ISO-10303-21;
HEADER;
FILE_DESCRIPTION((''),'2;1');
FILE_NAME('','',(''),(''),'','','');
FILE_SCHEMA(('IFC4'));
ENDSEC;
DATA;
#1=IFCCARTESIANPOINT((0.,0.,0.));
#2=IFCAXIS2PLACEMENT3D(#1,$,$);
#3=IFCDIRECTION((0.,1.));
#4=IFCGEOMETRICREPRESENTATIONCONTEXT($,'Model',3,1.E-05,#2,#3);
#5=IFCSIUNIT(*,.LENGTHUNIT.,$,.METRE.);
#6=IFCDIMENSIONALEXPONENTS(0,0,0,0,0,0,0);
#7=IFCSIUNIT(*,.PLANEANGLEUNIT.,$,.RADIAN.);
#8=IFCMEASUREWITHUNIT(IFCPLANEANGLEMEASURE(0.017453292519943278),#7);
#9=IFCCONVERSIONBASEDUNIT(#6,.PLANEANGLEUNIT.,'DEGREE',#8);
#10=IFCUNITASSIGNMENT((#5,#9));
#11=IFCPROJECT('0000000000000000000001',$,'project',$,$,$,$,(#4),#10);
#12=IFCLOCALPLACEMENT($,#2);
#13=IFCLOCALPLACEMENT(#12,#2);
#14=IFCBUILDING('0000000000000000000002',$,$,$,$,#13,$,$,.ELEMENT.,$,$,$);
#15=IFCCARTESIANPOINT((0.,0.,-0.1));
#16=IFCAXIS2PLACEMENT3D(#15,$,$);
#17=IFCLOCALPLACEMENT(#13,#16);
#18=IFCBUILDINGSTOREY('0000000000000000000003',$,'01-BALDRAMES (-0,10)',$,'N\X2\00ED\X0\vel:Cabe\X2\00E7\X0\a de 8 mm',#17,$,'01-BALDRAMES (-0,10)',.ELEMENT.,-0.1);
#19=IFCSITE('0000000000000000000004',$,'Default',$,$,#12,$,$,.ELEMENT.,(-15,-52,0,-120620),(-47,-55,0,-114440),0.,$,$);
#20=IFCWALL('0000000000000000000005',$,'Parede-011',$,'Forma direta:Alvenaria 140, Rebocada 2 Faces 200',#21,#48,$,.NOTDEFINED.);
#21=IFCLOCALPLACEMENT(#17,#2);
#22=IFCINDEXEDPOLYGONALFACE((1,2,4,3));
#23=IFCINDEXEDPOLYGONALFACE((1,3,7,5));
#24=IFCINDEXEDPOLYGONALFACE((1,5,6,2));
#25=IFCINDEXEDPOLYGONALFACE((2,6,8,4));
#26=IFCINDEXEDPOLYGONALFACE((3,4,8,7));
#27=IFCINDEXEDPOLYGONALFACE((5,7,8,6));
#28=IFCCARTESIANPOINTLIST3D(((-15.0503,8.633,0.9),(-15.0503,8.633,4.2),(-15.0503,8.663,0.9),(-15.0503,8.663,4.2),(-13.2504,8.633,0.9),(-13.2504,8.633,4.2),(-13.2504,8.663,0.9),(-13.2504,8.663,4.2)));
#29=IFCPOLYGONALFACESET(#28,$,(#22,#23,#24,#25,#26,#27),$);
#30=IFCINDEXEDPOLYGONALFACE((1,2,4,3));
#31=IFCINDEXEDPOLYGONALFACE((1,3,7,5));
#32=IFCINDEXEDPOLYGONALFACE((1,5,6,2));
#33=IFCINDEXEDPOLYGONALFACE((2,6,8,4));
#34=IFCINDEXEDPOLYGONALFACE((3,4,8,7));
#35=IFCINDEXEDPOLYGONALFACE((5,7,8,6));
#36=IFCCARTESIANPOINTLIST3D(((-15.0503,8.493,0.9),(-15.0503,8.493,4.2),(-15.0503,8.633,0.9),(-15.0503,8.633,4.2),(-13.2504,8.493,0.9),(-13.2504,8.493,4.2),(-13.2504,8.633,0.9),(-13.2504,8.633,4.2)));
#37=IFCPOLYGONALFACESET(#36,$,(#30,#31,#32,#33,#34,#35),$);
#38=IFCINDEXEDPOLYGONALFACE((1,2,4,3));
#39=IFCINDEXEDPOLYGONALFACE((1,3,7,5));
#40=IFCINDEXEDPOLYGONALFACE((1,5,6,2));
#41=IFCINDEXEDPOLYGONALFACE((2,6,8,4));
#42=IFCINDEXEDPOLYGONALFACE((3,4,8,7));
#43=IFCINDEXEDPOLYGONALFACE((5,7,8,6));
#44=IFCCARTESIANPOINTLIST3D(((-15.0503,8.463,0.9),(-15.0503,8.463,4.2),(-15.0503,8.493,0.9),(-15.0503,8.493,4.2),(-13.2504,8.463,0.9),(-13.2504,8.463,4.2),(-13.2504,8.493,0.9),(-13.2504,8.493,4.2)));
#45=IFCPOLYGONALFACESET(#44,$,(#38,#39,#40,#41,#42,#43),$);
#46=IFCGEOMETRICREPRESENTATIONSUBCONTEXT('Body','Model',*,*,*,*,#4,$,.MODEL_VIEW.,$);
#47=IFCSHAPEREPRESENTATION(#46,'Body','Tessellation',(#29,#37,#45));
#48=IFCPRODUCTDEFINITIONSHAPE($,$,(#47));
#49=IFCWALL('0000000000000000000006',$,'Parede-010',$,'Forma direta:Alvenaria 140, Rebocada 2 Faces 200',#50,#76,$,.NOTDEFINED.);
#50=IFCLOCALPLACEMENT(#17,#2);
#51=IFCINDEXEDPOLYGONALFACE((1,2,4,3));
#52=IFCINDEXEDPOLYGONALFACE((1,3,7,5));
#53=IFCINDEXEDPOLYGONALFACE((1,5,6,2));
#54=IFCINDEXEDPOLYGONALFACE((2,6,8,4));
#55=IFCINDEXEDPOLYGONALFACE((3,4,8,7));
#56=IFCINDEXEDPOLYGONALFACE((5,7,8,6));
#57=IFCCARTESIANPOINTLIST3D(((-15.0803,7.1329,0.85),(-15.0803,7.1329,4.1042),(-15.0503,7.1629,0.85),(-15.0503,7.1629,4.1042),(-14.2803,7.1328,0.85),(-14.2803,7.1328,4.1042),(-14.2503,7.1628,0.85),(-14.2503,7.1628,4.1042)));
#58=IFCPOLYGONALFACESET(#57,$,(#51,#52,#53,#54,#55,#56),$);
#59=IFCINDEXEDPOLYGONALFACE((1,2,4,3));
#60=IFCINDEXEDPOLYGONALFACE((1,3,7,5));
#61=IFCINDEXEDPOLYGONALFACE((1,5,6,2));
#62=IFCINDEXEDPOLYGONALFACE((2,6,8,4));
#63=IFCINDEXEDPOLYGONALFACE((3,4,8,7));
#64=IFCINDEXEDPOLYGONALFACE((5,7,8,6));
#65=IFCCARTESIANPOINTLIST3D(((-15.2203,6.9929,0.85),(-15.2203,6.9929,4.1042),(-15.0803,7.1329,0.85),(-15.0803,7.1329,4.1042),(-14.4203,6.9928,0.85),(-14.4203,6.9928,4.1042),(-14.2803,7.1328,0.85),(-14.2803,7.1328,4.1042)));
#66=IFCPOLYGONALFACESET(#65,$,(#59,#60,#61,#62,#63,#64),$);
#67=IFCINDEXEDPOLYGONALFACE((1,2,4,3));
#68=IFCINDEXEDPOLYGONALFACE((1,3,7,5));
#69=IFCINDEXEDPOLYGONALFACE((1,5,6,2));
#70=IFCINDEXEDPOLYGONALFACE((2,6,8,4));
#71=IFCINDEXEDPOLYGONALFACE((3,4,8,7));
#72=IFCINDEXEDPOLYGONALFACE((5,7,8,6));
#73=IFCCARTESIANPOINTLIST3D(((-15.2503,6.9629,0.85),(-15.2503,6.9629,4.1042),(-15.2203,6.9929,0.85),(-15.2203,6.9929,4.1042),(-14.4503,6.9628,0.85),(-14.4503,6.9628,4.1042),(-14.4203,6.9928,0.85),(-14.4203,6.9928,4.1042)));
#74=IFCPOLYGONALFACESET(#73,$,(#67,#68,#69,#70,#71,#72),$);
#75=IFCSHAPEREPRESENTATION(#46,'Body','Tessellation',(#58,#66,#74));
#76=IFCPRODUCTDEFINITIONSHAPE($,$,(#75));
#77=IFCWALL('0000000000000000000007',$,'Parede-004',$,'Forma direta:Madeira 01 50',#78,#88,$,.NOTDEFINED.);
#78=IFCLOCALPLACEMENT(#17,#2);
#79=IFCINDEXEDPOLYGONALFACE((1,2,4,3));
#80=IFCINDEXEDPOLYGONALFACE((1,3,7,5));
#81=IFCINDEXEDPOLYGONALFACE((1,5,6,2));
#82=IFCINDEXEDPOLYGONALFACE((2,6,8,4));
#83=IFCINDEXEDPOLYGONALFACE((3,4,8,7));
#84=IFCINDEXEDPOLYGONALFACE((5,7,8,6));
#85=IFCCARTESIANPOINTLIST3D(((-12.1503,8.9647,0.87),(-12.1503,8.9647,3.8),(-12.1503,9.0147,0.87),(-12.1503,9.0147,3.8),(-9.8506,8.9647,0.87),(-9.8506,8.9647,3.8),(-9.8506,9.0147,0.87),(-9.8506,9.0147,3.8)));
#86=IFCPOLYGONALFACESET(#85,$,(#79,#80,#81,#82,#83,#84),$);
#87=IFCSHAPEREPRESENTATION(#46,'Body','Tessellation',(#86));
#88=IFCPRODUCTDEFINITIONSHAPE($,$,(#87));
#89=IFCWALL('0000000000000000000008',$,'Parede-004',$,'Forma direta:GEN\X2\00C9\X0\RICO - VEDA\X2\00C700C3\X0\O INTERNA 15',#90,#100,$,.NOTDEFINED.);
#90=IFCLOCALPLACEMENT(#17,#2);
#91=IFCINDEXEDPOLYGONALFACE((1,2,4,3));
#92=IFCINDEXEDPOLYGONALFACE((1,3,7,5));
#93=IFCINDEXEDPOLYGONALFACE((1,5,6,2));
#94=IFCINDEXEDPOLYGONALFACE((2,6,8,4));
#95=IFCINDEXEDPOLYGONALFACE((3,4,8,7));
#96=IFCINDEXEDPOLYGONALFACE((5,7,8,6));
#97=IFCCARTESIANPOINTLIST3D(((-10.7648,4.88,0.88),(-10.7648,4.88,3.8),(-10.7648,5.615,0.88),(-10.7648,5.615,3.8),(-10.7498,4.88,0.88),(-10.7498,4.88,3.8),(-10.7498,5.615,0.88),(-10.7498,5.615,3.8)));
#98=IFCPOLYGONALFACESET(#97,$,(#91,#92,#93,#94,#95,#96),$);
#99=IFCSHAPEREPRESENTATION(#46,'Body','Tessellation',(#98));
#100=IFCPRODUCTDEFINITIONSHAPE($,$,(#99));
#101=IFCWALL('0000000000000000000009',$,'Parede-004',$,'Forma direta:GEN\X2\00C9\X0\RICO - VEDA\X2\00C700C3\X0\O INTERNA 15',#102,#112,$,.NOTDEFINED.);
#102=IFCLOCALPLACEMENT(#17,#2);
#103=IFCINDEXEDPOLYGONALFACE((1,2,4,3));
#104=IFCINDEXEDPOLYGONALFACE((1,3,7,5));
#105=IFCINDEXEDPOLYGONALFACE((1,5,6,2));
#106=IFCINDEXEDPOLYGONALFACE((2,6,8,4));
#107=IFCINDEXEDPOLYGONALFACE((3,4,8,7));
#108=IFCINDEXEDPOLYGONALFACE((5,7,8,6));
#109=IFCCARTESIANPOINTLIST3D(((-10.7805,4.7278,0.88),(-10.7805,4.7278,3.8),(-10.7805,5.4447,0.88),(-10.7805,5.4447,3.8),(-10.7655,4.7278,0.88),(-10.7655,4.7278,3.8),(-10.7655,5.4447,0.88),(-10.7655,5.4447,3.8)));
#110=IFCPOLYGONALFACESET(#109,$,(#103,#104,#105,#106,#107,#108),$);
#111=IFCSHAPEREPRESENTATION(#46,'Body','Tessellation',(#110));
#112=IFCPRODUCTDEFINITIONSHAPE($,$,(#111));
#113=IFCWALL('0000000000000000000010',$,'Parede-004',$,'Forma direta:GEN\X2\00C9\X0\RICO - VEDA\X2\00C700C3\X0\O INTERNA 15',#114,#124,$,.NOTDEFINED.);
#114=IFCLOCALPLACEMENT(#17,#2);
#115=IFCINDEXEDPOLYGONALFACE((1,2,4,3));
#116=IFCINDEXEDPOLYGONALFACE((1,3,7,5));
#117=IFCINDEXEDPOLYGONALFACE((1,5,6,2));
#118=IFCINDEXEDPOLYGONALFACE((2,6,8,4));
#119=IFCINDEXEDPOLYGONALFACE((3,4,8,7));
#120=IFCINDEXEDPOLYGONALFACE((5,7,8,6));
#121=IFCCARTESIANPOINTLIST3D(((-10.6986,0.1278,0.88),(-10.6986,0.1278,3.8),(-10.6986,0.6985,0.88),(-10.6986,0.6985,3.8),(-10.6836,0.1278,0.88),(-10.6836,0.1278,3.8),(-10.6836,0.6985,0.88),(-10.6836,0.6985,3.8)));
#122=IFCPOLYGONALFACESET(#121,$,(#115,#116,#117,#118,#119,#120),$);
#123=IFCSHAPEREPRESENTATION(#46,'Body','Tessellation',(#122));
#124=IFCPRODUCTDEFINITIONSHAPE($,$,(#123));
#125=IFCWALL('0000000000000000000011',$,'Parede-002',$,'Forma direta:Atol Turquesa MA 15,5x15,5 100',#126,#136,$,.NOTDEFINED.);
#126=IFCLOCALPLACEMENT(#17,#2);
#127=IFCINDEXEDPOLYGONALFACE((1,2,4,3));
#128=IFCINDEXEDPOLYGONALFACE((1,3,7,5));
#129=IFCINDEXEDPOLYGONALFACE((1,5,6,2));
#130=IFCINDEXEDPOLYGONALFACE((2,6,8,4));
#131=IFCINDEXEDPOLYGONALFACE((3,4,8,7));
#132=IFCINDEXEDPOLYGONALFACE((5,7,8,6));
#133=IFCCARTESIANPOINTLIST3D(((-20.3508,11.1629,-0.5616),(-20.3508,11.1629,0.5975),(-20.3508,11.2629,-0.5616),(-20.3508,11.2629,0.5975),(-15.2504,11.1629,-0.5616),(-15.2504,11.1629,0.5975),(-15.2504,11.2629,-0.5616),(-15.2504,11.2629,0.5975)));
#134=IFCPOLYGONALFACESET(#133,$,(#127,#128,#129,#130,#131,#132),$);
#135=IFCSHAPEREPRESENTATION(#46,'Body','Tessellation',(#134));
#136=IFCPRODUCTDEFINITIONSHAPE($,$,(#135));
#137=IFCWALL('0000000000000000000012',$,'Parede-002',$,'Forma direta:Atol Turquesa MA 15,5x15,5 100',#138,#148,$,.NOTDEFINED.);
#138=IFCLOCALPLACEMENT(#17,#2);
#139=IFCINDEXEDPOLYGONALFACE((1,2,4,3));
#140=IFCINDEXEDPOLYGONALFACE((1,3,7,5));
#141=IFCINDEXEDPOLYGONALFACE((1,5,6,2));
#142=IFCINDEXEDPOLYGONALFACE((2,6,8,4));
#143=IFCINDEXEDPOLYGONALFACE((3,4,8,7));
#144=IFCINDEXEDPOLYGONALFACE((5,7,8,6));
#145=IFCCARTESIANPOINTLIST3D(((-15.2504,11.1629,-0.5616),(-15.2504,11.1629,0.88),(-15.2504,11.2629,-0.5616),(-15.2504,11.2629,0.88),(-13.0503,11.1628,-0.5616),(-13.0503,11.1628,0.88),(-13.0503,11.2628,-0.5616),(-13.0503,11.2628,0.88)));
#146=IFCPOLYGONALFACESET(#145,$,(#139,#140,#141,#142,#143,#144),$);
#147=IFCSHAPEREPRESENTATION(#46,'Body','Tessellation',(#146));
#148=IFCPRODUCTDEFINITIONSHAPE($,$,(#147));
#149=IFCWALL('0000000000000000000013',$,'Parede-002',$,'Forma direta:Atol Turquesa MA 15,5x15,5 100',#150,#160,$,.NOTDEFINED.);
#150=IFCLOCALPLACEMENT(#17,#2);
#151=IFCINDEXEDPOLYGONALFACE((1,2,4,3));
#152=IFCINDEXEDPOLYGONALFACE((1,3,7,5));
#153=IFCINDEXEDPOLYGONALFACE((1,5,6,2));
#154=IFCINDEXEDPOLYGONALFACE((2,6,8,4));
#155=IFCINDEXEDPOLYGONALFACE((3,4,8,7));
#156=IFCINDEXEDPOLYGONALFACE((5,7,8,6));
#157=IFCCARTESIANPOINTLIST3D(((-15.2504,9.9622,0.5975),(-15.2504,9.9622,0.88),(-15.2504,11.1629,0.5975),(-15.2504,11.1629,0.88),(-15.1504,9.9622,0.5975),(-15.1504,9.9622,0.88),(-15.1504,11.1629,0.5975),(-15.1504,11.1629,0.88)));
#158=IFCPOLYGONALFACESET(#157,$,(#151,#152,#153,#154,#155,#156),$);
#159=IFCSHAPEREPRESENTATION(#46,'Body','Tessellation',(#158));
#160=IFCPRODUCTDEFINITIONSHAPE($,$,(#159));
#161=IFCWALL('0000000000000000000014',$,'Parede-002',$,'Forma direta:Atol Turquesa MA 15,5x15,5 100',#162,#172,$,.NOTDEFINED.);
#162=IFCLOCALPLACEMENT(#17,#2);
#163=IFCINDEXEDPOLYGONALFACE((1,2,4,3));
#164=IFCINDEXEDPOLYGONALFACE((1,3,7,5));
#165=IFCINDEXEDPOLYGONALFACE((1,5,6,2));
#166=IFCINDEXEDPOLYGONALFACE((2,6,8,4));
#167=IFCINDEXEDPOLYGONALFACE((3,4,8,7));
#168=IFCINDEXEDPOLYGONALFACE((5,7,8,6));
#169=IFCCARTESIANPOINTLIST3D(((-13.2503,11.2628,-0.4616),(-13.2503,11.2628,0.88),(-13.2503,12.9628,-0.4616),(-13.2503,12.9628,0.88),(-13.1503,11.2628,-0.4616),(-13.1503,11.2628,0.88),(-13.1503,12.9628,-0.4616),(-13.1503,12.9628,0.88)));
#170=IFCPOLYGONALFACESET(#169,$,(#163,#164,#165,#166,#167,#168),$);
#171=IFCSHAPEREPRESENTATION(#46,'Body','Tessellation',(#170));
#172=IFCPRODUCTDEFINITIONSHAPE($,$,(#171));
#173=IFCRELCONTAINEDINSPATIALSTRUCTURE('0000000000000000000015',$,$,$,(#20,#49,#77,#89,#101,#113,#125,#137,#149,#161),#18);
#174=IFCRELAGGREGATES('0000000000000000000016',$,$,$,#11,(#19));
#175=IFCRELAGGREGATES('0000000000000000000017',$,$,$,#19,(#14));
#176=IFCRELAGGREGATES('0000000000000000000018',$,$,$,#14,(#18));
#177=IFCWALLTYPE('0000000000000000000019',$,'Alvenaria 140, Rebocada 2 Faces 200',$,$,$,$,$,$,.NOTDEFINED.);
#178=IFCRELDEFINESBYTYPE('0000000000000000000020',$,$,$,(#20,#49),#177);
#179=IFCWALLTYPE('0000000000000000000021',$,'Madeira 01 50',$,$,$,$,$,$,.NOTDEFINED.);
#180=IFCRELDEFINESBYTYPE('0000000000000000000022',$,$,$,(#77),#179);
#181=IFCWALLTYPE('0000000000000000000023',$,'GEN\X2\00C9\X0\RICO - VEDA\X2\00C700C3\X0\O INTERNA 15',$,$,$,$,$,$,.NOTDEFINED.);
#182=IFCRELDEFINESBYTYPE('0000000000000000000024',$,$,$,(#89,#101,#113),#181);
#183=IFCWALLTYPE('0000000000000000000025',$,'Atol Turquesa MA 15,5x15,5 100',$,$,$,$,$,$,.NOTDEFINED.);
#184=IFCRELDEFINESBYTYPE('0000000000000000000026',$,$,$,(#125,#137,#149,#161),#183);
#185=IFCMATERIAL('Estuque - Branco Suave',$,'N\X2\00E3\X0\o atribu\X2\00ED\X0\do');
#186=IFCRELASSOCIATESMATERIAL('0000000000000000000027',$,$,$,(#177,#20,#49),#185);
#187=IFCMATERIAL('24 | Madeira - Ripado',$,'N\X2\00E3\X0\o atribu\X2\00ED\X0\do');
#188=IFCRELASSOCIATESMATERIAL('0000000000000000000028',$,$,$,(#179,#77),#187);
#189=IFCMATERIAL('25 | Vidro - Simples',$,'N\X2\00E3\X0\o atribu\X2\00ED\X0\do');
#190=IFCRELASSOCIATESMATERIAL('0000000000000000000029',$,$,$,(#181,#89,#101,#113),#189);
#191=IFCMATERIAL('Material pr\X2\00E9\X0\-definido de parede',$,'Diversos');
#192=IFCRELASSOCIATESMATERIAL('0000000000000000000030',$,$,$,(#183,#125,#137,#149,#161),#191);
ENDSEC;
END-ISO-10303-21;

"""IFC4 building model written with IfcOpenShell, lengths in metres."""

from ifc_helpers import new_model, entity, si_unit, converted_unit, direction, frame, origin, place, context, subcontext, project, spatial, indexed_curve, outline, extrude, material, type_object, element, save


model = new_model("IFC4")

# Units and contexts
model_context = context("Model", 3, precision=1e-05, world=origin(), true_north=direction((0.0, 1.0)))
body_context = subcontext(model_context, "Body", "Model", "MODEL_VIEW")
ifc_project = project(units=[si_unit("LENGTHUNIT", "METRE"), converted_unit("PLANEANGLEUNIT", "DEGREE", entity("IfcPlaneAngleMeasure", 0.017453292519943278), si_unit("PLANEANGLEUNIT", "RADIAN"), dimensions=[0, 0, 0, 0, 0, 0, 0])], contexts=[model_context])

# Site, building, storey
site_placement = place(None, origin())
site = spatial("IfcSite", under=ifc_project, at=site_placement, Name="Default", CompositionType="ELEMENT", RefLatitude=(-15, -52, 0, -120620), RefLongitude=(-47, -55, 0, -114440), RefElevation=0.0)
building_placement = place(site_placement, origin())
building = spatial("IfcBuilding", under=site, at=building_placement, CompositionType="ELEMENT")
storey_placement = place(building_placement, frame((0.0, 0.0, -0.1)))
storey = spatial("IfcBuildingStorey", under=building, at=storey_placement, Name="01-BALDRAMES (-0,10)", ObjectType="Nível:Cabeça de 8 mm", LongName="01-BALDRAMES (-0,10)", CompositionType="ELEMENT", Elevation=-0.1)

# Walls
ifc_material_1 = material(Name="Estuque - Branco Suave", Category="Não atribuído")
wall_type_1 = type_object("IfcWallType", Name="Alvenaria 140, Rebocada 2 Faces 200", PredefinedType="NOTDEFINED", material=ifc_material_1)
wall_1_placement = place(storey_placement, frame((-15.2503, 8.463, 0.9)))
element("IfcWall", 1, at=wall_1_placement, inside=storey, type_object=wall_type_1, material=ifc_material_1, Name="Parede-011", ObjectType="Forma direta:Alvenaria 140, Rebocada 2 Faces 200", PredefinedType="NOTDEFINED", context=body_context, shape_type="SweptSolid", body=[
    extrude(outline(indexed_curve([(-0.015, -0.9), (0.015, -0.9), (0.015, 0.9), (-0.015, 0.9), (-0.015, -0.9)], self_intersect=False)), frame((1.1, 0.185, 0.0), z_axis=(0.0, 0.0, 1.0), x_axis=(0.000013, 1.0, 0.0)), (0.0, 0.0, 1.0), 3.3),
    extrude(outline(indexed_curve([(-0.07, -0.9), (0.07, -0.9), (0.07, 0.9), (-0.07, 0.9), (-0.07, -0.9)], self_intersect=False)), frame((1.1, 0.1, 0.0), z_axis=(0.0, 0.0, 1.0), x_axis=(0.000001, -1.0, 0.0)), (0.0, 0.0, 1.0), 3.3),
    extrude(outline(indexed_curve([(-0.015, -0.9), (0.015, -0.9), (0.015, 0.9), (-0.015, 0.9), (-0.015, -0.9)], self_intersect=False)), frame((1.1, 0.015, 0.0), z_axis=(0.0, 0.0, 1.0), x_axis=(0.000001, -1.0, 0.0)), (0.0, 0.0, 1.0), 3.3),
])
wall_2_placement = place(storey_placement, frame((-15.2503, 6.9628, 0.85)))
element("IfcWall", 2, at=wall_2_placement, inside=storey, type_object=wall_type_1, material=ifc_material_1, Name="Parede-010", ObjectType="Forma direta:Alvenaria 140, Rebocada 2 Faces 200", PredefinedType="NOTDEFINED", context=body_context, shape_type="SweptSolid", body=[
    extrude(outline(indexed_curve([(0.2616, -0.2828), (0.3041, -0.2828), (-0.2616, 0.2828), (-0.3041, 0.2828), (0.2616, -0.2828)], self_intersect=False)), frame((0.585, 0.185, 0.0), z_axis=(0.0, 0.0, 1.0), x_axis=(0.707116, 0.707098, 0.0)), (0.0, 0.0, 1.0), 3.2542),
    extrude(outline(indexed_curve([(0.1838, -0.2828), (0.3818, -0.2828), (-0.1838, 0.2828), (-0.3818, 0.2828), (0.1838, -0.2828)], self_intersect=False)), frame((0.5, 0.1, 0.0), z_axis=(0.0, 0.0, 1.0), x_axis=(-0.707111, -0.707102, 0.0)), (0.0, 0.0, 1.0), 3.2542),
    extrude(outline(indexed_curve([(0.2616, -0.2828), (0.3041, -0.2828), (-0.2616, 0.2828), (-0.3041, 0.2828), (0.2616, -0.2828)], self_intersect=False)), frame((0.415, 0.015, 0.0), z_axis=(0.0, 0.0, 1.0), x_axis=(-0.707111, -0.707102, 0.0)), (0.0, 0.0, 1.0), 3.2542),
])
ifc_material_2 = material(Name="24 | Madeira - Ripado", Category="Não atribuído")
wall_type_2 = type_object("IfcWallType", Name="Madeira 01 50", PredefinedType="NOTDEFINED", material=ifc_material_2)
wall_3_placement = place(storey_placement, frame((-12.1503, 8.9647, 0.87)))
element("IfcWall", 3, at=wall_3_placement, inside=storey, type_object=wall_type_2, material=ifc_material_2, Name="Parede-004", ObjectType="Forma direta:Madeira 01 50", PredefinedType="NOTDEFINED", context=body_context, shape_type="SweptSolid", body=[
    extrude(outline(indexed_curve([(-0.025, -1.1499), (0.025, -1.1499), (0.025, 1.1499), (-0.025, 1.1499), (-0.025, -1.1499)], self_intersect=False)), frame((1.1499, 0.025, 0.0), z_axis=(0.0, 0.0, 1.0), x_axis=(-0.000013, -1.0, 0.0)), (0.0, 0.0, 1.0), 2.93),
])
ifc_material_3 = material(Name="25 | Vidro - Simples", Category="Não atribuído")
wall_type_3 = type_object("IfcWallType", Name="GENÉRICO - VEDAÇÃO INTERNA 15", PredefinedType="NOTDEFINED", material=ifc_material_3)
wall_4_placement = place(storey_placement, frame((-10.7648, 4.88, 0.88), z_axis=(0.0, 0.0, 1.0), x_axis=(0.0, 1.0, 0.0)))
element("IfcWall", 4, at=wall_4_placement, inside=storey, type_object=wall_type_3, material=ifc_material_3, Name="Parede-004", ObjectType="Forma direta:GENÉRICO - VEDAÇÃO INTERNA 15", PredefinedType="NOTDEFINED", context=body_context, shape_type="SweptSolid", body=[
    extrude(outline(indexed_curve([(-0.0075, -0.3675), (0.0075, -0.3675), (0.0075, 0.3675), (-0.0075, 0.3675), (-0.0075, -0.3675)], self_intersect=False)), frame((0.3675, -0.0075, 0.0), z_axis=(0.0, 0.0, 1.0), x_axis=(-0.000013, -1.0, 0.0)), (0.0, 0.0, 1.0), 2.92),
])
wall_5_placement = place(storey_placement, frame((-10.7805, 4.7278, 0.88), z_axis=(0.0, 0.0, 1.0), x_axis=(0.0, 1.0, 0.0)))
element("IfcWall", 5, at=wall_5_placement, inside=storey, type_object=wall_type_3, material=ifc_material_3, Name="Parede-004", ObjectType="Forma direta:GENÉRICO - VEDAÇÃO INTERNA 15", PredefinedType="NOTDEFINED", context=body_context, shape_type="SweptSolid", body=[
    extrude(outline(indexed_curve([(-0.0075, -0.3584), (0.0075, -0.3584), (0.0075, 0.3584), (-0.0075, 0.3584), (-0.0075, -0.3584)], self_intersect=False)), frame((0.3584, -0.0075, 0.0), z_axis=(0.0, 0.0, 1.0), x_axis=(-0.000013, -1.0, 0.0)), (0.0, 0.0, 1.0), 2.92),
])
wall_6_placement = place(storey_placement, frame((-10.6986, 0.1278, 0.88), z_axis=(0.0, 0.0, 1.0), x_axis=(0.0, 1.0, 0.0)))
element("IfcWall", 6, at=wall_6_placement, inside=storey, type_object=wall_type_3, material=ifc_material_3, Name="Parede-004", ObjectType="Forma direta:GENÉRICO - VEDAÇÃO INTERNA 15", PredefinedType="NOTDEFINED", context=body_context, shape_type="SweptSolid", body=[
    extrude(outline(indexed_curve([(-0.0075, -0.2854), (0.0075, -0.2854), (0.0075, 0.2854), (-0.0075, 0.2854), (-0.0075, -0.2854)], self_intersect=False)), frame((0.2854, -0.0075, 0.0), z_axis=(0.0, 0.0, 1.0), x_axis=(0.000047, 1.0, 0.0)), (0.0, 0.0, 1.0), 2.92),
])
ifc_material_4 = material(Name="Material pré-definido de parede", Category="Diversos")
wall_type_4 = type_object("IfcWallType", Name="Atol Turquesa MA 15,5x15,5 100", PredefinedType="NOTDEFINED", material=ifc_material_4)
wall_7_placement = place(storey_placement, frame((-20.3508, 11.1629, -0.5616)))
element("IfcWall", 7, at=wall_7_placement, inside=storey, type_object=wall_type_4, material=ifc_material_4, Name="Parede-002", ObjectType="Forma direta:Atol Turquesa MA 15,5x15,5 100", PredefinedType="NOTDEFINED", context=body_context, shape_type="SweptSolid", body=[
    extrude(outline(indexed_curve([(-0.05, -2.5502), (0.05, -2.5502), (0.05, 2.5502), (-0.05, 2.5502), (-0.05, -2.5502)], self_intersect=False)), frame((2.5502, 0.05, 0.0), z_axis=(0.0, 0.0, 1.0), x_axis=(-0.000013, -1.0, 0.0)), (0.0, 0.0, 1.0), 1.1591),
])
wall_8_placement = place(storey_placement, frame((-15.2504, 11.1628, -0.5616)))
element("IfcWall", 8, at=wall_8_placement, inside=storey, type_object=wall_type_4, material=ifc_material_4, Name="Parede-002", ObjectType="Forma direta:Atol Turquesa MA 15,5x15,5 100", PredefinedType="NOTDEFINED", context=body_context, shape_type="SweptSolid", body=[
    extrude(outline(indexed_curve([(-0.05, -1.1), (0.05, -1.1), (0.05, 1.1), (-0.05, 1.1), (-0.05, -1.1)], self_intersect=False)), frame((1.1, 0.05, 0.0), z_axis=(0.0, 0.0, 1.0), x_axis=(-0.000013, -1.0, 0.0)), (0.0, 0.0, 1.0), 1.4416),
])
wall_9_placement = place(storey_placement, frame((-15.2504, 9.9622, 0.5975), z_axis=(0.0, 0.0, 1.0), x_axis=(0.0, 1.0, 0.0)))
element("IfcWall", 9, at=wall_9_placement, inside=storey, type_object=wall_type_4, material=ifc_material_4, Name="Parede-002", ObjectType="Forma direta:Atol Turquesa MA 15,5x15,5 100", PredefinedType="NOTDEFINED", context=body_context, shape_type="SweptSolid", body=[
    extrude(outline(indexed_curve([(-0.05, -0.6003), (0.05, -0.6003), (0.05, 0.6003), (-0.05, 0.6003), (-0.05, -0.6003)], self_intersect=False)), frame((0.6003, -0.05, 0.0), z_axis=(0.0, 0.0, 1.0), x_axis=(-0.000013, -1.0, 0.0)), (0.0, 0.0, 1.0), 0.2825),
])
wall_10_placement = place(storey_placement, frame((-13.2503, 11.2628, -0.4616), z_axis=(0.0, 0.0, 1.0), x_axis=(0.0, 1.0, 0.0)))
element("IfcWall", 10, at=wall_10_placement, inside=storey, type_object=wall_type_4, material=ifc_material_4, Name="Parede-002", ObjectType="Forma direta:Atol Turquesa MA 15,5x15,5 100", PredefinedType="NOTDEFINED", context=body_context, shape_type="SweptSolid", body=[
    extrude(outline(indexed_curve([(-0.05, -0.85), (0.05, -0.85), (0.05, 0.85), (-0.05, 0.85), (-0.05, -0.85)], self_intersect=False)), frame((0.85, -0.05, 0.0), z_axis=(0.0, 0.0, 1.0), x_axis=(-0.000013, -1.0, 0.0)), (0.0, 0.0, 1.0), 1.3416),
])

save(model, "model.ifc")
